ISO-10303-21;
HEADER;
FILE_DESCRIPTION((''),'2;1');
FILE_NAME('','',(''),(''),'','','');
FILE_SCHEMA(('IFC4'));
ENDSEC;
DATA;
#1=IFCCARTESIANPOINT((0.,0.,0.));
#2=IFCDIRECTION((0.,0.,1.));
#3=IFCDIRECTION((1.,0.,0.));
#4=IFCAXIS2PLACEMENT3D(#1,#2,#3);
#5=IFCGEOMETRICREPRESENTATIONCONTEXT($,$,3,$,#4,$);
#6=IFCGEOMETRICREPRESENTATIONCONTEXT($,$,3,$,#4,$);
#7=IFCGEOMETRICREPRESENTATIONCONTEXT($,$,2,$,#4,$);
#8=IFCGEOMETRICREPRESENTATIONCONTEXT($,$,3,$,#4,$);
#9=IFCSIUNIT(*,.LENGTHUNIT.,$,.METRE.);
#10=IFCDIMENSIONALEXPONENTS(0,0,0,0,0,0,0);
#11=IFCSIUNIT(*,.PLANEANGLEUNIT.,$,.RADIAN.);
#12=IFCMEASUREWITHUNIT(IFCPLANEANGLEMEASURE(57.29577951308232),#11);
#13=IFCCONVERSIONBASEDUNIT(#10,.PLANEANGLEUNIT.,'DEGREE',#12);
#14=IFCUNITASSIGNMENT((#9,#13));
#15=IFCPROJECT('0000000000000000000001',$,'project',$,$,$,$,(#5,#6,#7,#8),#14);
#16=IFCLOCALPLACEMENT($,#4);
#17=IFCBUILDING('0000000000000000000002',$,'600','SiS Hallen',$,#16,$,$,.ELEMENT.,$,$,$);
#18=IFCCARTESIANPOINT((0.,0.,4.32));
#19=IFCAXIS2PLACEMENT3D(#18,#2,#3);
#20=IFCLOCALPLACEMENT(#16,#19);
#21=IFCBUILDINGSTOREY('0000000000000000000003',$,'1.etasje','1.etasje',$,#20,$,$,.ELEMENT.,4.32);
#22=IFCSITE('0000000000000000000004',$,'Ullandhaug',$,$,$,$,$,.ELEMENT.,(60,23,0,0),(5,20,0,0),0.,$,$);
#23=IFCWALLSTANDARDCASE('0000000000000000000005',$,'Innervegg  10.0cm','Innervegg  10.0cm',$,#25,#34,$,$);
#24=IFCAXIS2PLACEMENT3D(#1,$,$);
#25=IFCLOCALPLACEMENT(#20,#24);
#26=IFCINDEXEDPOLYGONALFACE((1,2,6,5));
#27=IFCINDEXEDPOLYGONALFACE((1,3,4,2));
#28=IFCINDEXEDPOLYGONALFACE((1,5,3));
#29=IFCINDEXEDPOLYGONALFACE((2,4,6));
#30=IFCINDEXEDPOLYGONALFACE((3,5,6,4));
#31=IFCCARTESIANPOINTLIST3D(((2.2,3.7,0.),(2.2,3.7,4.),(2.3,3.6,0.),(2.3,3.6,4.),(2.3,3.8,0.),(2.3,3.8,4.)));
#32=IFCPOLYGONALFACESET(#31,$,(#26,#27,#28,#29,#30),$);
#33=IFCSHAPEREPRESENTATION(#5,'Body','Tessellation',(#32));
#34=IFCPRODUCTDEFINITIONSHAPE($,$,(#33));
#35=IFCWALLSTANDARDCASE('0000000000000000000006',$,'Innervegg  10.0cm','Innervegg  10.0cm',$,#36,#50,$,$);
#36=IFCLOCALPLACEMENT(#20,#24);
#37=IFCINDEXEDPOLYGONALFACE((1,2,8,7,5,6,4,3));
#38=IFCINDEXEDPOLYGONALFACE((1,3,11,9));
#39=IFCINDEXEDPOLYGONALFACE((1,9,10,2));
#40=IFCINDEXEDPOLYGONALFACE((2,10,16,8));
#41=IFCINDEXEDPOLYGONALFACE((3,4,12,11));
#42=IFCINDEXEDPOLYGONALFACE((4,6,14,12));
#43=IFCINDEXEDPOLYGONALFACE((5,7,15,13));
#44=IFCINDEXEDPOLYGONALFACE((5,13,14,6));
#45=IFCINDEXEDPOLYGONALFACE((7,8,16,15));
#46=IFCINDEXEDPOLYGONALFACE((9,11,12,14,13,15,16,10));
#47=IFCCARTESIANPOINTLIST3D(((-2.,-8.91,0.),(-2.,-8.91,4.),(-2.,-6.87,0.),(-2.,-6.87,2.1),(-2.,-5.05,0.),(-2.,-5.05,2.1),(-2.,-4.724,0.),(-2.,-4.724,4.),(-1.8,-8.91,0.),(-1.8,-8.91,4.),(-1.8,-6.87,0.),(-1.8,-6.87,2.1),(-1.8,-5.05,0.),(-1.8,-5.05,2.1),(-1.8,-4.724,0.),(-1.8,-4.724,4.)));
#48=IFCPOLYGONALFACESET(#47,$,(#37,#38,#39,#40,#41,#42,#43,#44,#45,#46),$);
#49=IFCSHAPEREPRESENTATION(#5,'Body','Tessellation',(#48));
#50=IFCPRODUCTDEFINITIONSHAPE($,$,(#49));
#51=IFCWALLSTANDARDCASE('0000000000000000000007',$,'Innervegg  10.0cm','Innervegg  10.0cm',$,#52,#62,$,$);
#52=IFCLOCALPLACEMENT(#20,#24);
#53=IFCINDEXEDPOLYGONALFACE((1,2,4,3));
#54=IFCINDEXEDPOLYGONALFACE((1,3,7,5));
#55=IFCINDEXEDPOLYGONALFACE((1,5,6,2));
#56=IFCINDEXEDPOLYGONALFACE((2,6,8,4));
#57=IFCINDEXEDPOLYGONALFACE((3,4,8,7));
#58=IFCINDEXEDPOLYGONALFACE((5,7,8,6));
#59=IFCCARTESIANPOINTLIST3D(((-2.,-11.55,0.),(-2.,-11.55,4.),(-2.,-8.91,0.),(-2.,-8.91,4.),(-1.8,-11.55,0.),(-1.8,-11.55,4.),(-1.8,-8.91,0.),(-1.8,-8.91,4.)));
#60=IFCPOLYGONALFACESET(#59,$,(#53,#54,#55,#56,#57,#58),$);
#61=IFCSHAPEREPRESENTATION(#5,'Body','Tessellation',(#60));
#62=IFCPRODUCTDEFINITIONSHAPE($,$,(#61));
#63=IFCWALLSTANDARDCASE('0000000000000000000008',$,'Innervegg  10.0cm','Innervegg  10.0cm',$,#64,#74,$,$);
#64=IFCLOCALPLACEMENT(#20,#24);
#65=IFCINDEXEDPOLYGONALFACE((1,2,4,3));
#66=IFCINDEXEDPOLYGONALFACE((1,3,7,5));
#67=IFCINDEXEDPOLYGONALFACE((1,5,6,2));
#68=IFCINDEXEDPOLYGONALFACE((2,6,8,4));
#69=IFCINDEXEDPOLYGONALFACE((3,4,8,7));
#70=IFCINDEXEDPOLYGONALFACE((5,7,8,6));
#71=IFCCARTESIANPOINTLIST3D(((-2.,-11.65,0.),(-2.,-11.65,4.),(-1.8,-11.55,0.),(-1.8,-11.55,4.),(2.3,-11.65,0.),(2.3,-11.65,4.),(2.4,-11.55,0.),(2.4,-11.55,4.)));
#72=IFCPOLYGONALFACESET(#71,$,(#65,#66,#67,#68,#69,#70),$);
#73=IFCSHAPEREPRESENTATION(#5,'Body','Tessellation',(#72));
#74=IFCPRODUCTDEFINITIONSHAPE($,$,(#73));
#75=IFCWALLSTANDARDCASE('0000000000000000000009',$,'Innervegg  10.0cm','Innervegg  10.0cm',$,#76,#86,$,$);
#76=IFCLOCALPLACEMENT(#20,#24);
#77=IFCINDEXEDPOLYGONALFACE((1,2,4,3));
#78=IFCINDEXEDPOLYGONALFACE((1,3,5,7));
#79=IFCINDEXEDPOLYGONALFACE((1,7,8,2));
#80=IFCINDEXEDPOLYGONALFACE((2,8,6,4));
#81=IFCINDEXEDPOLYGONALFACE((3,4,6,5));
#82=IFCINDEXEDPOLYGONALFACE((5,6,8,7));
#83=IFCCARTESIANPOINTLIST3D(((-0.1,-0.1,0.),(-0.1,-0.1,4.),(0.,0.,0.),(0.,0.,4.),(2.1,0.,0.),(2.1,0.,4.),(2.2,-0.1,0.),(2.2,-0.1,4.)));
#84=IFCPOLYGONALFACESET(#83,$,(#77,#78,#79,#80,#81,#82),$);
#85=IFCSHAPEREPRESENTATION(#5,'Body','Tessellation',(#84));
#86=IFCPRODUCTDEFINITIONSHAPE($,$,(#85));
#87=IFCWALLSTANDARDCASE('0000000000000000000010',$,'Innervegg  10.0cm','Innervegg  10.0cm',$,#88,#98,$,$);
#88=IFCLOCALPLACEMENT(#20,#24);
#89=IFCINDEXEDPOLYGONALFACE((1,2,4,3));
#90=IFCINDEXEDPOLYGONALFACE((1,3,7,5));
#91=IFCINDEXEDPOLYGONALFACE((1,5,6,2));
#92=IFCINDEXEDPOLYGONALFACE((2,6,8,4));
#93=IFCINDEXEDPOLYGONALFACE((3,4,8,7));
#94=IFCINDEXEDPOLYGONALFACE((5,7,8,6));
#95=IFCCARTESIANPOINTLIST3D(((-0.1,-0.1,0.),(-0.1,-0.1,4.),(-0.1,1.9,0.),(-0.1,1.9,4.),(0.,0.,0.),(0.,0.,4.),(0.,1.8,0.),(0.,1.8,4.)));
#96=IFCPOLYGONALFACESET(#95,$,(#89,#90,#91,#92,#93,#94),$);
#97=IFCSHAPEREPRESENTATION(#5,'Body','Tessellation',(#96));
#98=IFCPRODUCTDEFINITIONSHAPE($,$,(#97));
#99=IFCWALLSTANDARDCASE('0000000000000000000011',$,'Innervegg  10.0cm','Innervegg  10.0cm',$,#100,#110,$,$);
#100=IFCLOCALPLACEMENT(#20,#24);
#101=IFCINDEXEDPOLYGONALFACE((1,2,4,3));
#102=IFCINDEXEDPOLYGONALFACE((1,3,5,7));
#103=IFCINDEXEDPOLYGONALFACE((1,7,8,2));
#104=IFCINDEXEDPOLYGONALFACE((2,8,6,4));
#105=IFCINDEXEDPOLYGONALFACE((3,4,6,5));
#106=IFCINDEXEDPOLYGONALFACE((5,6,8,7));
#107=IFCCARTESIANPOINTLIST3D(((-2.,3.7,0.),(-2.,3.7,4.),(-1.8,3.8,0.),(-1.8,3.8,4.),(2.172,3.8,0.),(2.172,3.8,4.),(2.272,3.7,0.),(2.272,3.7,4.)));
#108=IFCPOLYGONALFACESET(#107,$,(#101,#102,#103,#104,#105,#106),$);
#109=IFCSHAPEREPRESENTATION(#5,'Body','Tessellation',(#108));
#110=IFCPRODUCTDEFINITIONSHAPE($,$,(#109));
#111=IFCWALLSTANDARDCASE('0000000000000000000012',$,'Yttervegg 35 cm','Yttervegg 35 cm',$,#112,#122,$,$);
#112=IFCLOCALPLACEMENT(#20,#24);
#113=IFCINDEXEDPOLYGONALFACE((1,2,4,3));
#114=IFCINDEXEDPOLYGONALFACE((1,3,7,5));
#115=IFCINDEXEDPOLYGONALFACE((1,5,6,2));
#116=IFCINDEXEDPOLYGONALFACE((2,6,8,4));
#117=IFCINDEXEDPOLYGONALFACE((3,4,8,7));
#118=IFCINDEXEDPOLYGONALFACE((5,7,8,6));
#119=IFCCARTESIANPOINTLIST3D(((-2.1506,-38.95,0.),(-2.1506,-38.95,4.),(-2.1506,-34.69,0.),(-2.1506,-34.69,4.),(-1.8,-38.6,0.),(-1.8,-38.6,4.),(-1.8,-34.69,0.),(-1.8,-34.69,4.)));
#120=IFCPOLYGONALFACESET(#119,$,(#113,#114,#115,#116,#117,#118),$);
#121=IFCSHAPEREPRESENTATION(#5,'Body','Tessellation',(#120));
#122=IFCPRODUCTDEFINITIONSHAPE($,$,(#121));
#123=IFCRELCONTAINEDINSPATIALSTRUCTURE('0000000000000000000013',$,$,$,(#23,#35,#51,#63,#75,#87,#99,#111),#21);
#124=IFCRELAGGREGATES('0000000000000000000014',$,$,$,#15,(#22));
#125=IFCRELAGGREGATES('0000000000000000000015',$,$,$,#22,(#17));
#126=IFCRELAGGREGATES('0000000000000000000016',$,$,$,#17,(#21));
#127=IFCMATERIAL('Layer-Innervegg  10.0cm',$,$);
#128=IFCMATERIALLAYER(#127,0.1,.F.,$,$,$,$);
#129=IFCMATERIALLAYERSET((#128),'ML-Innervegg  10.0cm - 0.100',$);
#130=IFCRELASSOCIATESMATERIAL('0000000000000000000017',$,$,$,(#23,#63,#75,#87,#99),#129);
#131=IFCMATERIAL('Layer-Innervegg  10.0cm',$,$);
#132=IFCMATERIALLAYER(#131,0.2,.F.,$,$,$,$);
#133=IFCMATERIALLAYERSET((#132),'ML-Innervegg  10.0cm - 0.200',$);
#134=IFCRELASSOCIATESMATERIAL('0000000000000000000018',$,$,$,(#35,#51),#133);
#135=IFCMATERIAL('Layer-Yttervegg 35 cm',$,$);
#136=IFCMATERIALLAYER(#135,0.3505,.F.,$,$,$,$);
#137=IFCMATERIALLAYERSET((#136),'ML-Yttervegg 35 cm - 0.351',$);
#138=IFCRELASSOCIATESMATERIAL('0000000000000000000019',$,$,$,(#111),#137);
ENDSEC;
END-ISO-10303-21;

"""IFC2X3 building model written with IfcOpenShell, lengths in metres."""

from ifc_helpers import new_model, entity, si_unit, converted_unit, frame, origin_with_axes, place, context, project, spatial, polyline, outline, extrude, material, layer, layer_set, layer_usage, element, save


model = new_model("IFC2X3")

# Units and contexts
context_of_model_1 = context(None, 3, world=origin_with_axes())
context_of_model_2 = context(None, 3, world=origin_with_axes())
context_of_model_3 = context(None, 2, world=origin_with_axes())
context_of_model_4 = context(None, 3, world=origin_with_axes())
ifc_project = project(units=[si_unit("LENGTHUNIT", "METRE"), converted_unit("PLANEANGLEUNIT", "DEGREE", entity("IfcPlaneAngleMeasure", 57.29577951308232), si_unit("PLANEANGLEUNIT", "RADIAN"), dimensions=[0, 0, 0, 0, 0, 0, 0])], contexts=[context_of_model_1, context_of_model_2, context_of_model_3, context_of_model_4])

# Site, building, storey
site = spatial("IfcSite", under=ifc_project, Name="Ullandhaug", CompositionType="ELEMENT", RefLatitude=(60, 23, 0, 0), RefLongitude=(5, 20, 0, 0), RefElevation=0.0)
building_placement = place(None, origin_with_axes())
building = spatial("IfcBuilding", under=site, at=building_placement, Name="600", Description="SiS Hallen", CompositionType="ELEMENT")
storey_placement = place(building_placement, frame((0.0, 0.0, 4.32), z_axis=(0.0, 0.0, 1.0), x_axis=(1.0, 0.0, 0.0)))
storey = spatial("IfcBuildingStorey", under=building, at=storey_placement, Name="1.etasje", Description="1.etasje", CompositionType="ELEMENT", Elevation=4.32)

# Shared definitions
ifc_material_1 = material(Name="Layer-Yttervegg 35 cm")
ifc_layer_1 = layer(ifc_material_1, 0.3505, ventilated=False)
ifc_layer_set_1 = layer_set([ifc_layer_1], Name="ML-Yttervegg 35 cm - 0.351")
ifc_layer_usage_1 = layer_usage(ifc_layer_set_1, "AXIS2", "POSITIVE", 0.0)

# Shared definitions
ifc_material_2 = material(Name="Layer-Innervegg  10.0cm")
ifc_layer_2 = layer(ifc_material_2, 0.1, ventilated=False)
ifc_layer_set_2 = layer_set([ifc_layer_2], Name="ML-Innervegg  10.0cm - 0.100")
ifc_layer_usage_2 = layer_usage(ifc_layer_set_2, "AXIS2", "POSITIVE", 0.0)

# Shared definitions
ifc_material_3 = material(Name="Layer-Innervegg  10.0cm")
ifc_layer_3 = layer(ifc_material_3, 0.2, ventilated=False)
ifc_layer_set_3 = layer_set([ifc_layer_3], Name="ML-Innervegg  10.0cm - 0.200")
ifc_layer_usage_3 = layer_usage(ifc_layer_set_3, "AXIS2", "POSITIVE", 0.0)

# Wall
wall_1_placement = place(storey_placement, frame((2.2, 3.7, 0.0), z_axis=(0.0, 0.0, 1.0), x_axis=(1.0, 0.0, 0.0)))
element("IfcWallStandardCase", 1, at=wall_1_placement, inside=storey, material=ifc_layer_usage_2, Name="Innervegg  10.0cm", Description="Innervegg  10.0cm", context=context_of_model_1, shape_type="SweptSolid", body=[
    extrude(outline(polyline([(0.0, 0.0), (0.0, 0.0), (0.1414, 0.0), (0.0, 0.1414), (0.0, 0.0)])), frame((0.0, 0.0, 0.0), z_axis=(0.0, 0.0, 1.0), x_axis=(0.707107, -0.707107, 0.0)), (0.0, 0.0, 1.0), 4.0),
])

# Wall, opening
wall_2_placement = place(storey_placement, frame((-2.0, -4.724, 0.0), z_axis=(0.0, 0.0, 1.0), x_axis=(0.0, -1.0, 0.0)))
wall_2 = element("IfcWallStandardCase", 2, at=wall_2_placement, inside=storey, material=ifc_layer_usage_3, Name="Innervegg  10.0cm", Description="Innervegg  10.0cm", context=context_of_model_1, shape_type="SweptSolid", body=[
    extrude(outline(polyline([(0.0, 0.0), (4.186, 0.0), (4.186, 0.2), (0.0, 0.2), (0.0, 0.0)])), frame((0.0, 0.0, 0.0), z_axis=(0.0, 0.0, 1.0), x_axis=(1.0, 0.0, 0.0)), (0.0, 0.0, 1.0), 4.0),
])
opening_1_placement = place(wall_2_placement, frame((0.326, 0.2, 0.0), z_axis=(0.0, 0.0, 1.0), x_axis=(1.0, 0.0, 0.0)))
element("IfcOpeningElement", 3, at=opening_1_placement, cuts=wall_2, context=context_of_model_1, shape_type="SweptSolid", body=[
    extrude(outline(polyline([(0.0, 0.0), (2.1, 0.0), (2.1, 1.82), (0.0, 1.82), (0.0, 0.0)])), frame((0.0, 0.0, 0.0), z_axis=(0.0, 1.0, 0.0), x_axis=(0.0, 0.0, 1.0)), (0.0, 0.0, -1.0), 0.2),
])

# Walls
wall_3_placement = place(storey_placement, frame((-2.0, -8.91, 0.0), z_axis=(0.0, 0.0, 1.0), x_axis=(0.0, -1.0, 0.0)))
element("IfcWallStandardCase", 4, at=wall_3_placement, inside=storey, material=ifc_layer_usage_3, Name="Innervegg  10.0cm", Description="Innervegg  10.0cm", context=context_of_model_1, shape_type="SweptSolid", body=[
    extrude(outline(polyline([(0.0, 0.0), (2.64, 0.0), (2.64, 0.2), (0.0, 0.2), (0.0, 0.0)])), frame((0.0, 0.0, 0.0), z_axis=(0.0, 0.0, 1.0), x_axis=(1.0, 0.0, 0.0)), (0.0, 0.0, 1.0), 4.0),
])
wall_4_placement = place(storey_placement, frame((-2.0, -11.65, 0.0), z_axis=(0.0, 0.0, 1.0), x_axis=(1.0, 0.0, 0.0)))
element("IfcWallStandardCase", 5, at=wall_4_placement, inside=storey, material=ifc_layer_usage_2, Name="Innervegg  10.0cm", Description="Innervegg  10.0cm", context=context_of_model_1, shape_type="SweptSolid", body=[
    extrude(outline(polyline([(0.0, 0.0), (4.3, 0.0), (4.4, 0.1), (0.2, 0.1), (0.0, 0.0)])), origin_with_axes(), (0.0, 0.0, 1.0), 4.0),
])
wall_5_placement = place(storey_placement, frame((-0.1, -0.1, 0.0), z_axis=(0.0, 0.0, 1.0), x_axis=(1.0, 0.0, 0.0)))
element("IfcWallStandardCase", 6, at=wall_5_placement, inside=storey, material=ifc_layer_usage_2, Name="Innervegg  10.0cm", Description="Innervegg  10.0cm", context=context_of_model_1, shape_type="SweptSolid", body=[
    extrude(outline(polyline([(0.0, 0.0), (2.3, 0.0), (2.2, 0.1), (0.1, 0.1), (0.0, 0.0)])), frame((0.0, 0.0, 0.0), z_axis=(0.0, 0.0, 1.0), x_axis=(1.0, 0.0, 0.0)), (0.0, 0.0, 1.0), 4.0),
])
wall_6_placement = place(storey_placement, frame((-0.1, 1.9, 0.0), z_axis=(0.0, 0.0, 1.0), x_axis=(0.0, -1.0, 0.0)))
element("IfcWallStandardCase", 7, at=wall_6_placement, inside=storey, material=ifc_layer_usage_2, Name="Innervegg  10.0cm", Description="Innervegg  10.0cm", context=context_of_model_1, shape_type="SweptSolid", body=[
    extrude(outline(polyline([(0.0, 0.0), (2.0, 0.0), (1.9, 0.1), (0.1, 0.1), (0.0, 0.0)])), frame((0.0, 0.0, 0.0), z_axis=(0.0, 0.0, 1.0), x_axis=(1.0, 0.0, 0.0)), (0.0, 0.0, 1.0), 4.0),
])
wall_7_placement = place(storey_placement, frame((-2.0, 3.7, 0.0), z_axis=(0.0, 0.0, 1.0), x_axis=(1.0, 0.0, 0.0)))
element("IfcWallStandardCase", 8, at=wall_7_placement, inside=storey, material=ifc_layer_usage_2, Name="Innervegg  10.0cm", Description="Innervegg  10.0cm", context=context_of_model_1, shape_type="SweptSolid", body=[
    extrude(outline(polyline([(0.0, 0.0), (4.272, 0.0), (4.172, 0.1), (0.2, 0.1), (0.0, 0.0)])), origin_with_axes(), (0.0, 0.0, 1.0), 4.0),
])
wall_8_placement = place(storey_placement, frame((-2.1506, -34.69, 0.0), z_axis=(0.0, 0.0, 1.0), x_axis=(0.0, -1.0, 0.0)))
element("IfcWallStandardCase", 9, at=wall_8_placement, inside=storey, material=ifc_layer_usage_1, Name="Yttervegg 35 cm", Description="Yttervegg 35 cm", context=context_of_model_1, shape_type="SweptSolid", body=[
    extrude(outline(polyline([(0.0, 0.0), (4.26, 0.0), (3.91, 0.3506), (0.0, 0.3506), (0.0, 0.0)])), frame((0.0, 0.0, 0.0), z_axis=(0.0, 0.0, 1.0), x_axis=(1.0, 0.0, 0.0)), (0.0, 0.0, 1.0), 4.0),
])

save(model, "model.ifc")
